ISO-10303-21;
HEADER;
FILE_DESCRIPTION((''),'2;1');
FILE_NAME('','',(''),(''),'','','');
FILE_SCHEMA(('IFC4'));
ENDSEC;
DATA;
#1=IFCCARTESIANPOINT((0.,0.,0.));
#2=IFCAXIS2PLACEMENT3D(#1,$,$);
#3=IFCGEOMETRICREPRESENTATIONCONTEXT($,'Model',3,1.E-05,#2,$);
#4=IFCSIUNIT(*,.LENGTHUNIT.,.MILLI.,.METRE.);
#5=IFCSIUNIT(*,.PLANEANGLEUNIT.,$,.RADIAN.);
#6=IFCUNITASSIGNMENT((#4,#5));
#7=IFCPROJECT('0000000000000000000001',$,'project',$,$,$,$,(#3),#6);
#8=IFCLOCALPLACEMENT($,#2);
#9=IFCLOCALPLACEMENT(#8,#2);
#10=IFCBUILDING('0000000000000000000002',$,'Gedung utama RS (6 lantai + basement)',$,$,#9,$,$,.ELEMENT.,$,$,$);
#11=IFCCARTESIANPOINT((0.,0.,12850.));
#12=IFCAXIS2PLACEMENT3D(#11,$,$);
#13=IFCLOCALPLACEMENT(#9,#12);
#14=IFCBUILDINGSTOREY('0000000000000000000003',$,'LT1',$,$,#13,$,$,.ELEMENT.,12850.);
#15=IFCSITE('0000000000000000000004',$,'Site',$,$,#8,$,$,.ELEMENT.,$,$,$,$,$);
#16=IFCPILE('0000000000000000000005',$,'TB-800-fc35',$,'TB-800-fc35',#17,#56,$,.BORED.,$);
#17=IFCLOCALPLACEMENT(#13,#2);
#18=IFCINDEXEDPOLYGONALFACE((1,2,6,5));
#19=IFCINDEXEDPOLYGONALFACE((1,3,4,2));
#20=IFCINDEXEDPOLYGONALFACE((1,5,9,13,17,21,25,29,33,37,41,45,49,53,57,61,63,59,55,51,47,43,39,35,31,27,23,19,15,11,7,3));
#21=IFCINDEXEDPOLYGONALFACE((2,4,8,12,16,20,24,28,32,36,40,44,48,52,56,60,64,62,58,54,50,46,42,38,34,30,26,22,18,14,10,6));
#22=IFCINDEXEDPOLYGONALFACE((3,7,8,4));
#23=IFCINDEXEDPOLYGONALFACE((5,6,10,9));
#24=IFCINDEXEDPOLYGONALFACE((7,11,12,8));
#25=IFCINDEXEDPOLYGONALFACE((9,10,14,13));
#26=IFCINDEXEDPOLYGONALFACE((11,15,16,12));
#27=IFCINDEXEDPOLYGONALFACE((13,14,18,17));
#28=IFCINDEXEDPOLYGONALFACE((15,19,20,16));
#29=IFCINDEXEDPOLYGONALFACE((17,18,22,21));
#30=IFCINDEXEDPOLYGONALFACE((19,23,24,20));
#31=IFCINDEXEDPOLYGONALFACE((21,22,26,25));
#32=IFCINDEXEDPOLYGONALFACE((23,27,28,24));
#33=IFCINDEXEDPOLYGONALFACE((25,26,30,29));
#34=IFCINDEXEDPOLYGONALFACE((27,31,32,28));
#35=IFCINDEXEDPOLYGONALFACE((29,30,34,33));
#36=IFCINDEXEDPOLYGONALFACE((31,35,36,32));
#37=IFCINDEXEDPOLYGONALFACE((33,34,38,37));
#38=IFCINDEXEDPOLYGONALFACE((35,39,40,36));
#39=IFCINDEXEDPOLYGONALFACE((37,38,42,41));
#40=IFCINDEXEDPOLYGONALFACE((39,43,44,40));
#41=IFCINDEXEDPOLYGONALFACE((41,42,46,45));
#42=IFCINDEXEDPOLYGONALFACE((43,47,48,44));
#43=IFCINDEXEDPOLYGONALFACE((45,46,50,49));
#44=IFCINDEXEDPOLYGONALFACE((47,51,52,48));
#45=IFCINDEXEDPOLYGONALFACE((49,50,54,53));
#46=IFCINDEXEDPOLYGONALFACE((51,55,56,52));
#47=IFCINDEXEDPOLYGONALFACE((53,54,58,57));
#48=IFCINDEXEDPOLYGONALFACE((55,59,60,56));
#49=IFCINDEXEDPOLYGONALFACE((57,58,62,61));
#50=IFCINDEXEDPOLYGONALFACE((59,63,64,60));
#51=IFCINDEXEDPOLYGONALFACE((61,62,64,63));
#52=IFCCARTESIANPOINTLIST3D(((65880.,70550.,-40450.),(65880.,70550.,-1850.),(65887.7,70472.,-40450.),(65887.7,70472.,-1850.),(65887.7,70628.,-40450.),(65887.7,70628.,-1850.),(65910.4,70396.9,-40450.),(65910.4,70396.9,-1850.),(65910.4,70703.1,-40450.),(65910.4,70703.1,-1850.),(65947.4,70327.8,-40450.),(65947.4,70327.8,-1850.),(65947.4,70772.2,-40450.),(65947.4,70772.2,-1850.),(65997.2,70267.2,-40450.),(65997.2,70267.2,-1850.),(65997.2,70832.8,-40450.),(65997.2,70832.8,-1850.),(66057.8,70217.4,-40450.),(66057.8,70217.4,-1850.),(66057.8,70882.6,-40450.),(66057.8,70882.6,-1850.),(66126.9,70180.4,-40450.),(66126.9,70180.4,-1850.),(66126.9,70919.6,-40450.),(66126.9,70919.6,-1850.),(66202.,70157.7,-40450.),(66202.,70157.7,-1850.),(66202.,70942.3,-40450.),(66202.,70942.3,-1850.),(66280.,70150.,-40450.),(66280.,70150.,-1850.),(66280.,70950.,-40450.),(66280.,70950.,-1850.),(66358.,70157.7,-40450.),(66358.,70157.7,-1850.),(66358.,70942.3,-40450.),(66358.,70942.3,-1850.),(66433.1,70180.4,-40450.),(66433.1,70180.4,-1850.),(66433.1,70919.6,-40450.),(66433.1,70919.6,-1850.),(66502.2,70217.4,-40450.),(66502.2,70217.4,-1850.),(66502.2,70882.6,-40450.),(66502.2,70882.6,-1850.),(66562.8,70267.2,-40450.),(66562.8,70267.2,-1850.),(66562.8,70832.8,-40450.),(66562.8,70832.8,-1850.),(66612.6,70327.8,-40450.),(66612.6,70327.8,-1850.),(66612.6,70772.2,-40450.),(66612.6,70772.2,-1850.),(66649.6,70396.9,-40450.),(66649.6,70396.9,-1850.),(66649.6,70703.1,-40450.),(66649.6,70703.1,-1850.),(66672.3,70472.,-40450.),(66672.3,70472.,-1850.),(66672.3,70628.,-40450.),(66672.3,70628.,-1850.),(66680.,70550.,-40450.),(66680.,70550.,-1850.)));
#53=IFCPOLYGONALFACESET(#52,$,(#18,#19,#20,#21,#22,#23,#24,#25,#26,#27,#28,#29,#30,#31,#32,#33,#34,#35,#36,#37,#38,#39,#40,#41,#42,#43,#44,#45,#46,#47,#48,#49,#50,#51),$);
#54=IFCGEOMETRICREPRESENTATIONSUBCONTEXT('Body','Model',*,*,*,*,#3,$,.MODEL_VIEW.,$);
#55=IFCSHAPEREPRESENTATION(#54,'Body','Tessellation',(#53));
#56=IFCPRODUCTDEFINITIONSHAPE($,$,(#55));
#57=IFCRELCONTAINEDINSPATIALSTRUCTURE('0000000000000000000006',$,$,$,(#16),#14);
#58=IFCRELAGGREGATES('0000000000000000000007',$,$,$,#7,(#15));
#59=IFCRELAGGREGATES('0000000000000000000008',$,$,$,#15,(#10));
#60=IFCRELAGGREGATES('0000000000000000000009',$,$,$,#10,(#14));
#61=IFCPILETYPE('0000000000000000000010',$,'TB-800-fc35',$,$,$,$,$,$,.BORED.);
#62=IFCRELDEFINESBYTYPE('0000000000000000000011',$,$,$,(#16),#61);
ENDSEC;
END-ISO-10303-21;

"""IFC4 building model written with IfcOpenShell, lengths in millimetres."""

from ifc_helpers import new_model, si_unit, frame, origin, origin_2d, place, context, subcontext, project, spatial, circle, extrude, material_profile, profile_set, profile_usage, type_object, element, save


model = new_model("IFC4")

# Units and contexts
model_context = context("Model", 3, precision=1e-05, world=origin())
body_context = subcontext(model_context, "Body", "Model", "MODEL_VIEW")
ifc_project = project(units=[si_unit("LENGTHUNIT", "METRE", prefix="MILLI"), si_unit("PLANEANGLEUNIT", "RADIAN")], contexts=[model_context])

# Site, building, storey
site_placement = place(None, origin())
site = spatial("IfcSite", under=ifc_project, at=site_placement, Name="Site", CompositionType="ELEMENT")
building_placement = place(site_placement, origin())
building = spatial("IfcBuilding", under=site, at=building_placement, Name="Gedung utama RS (6 lantai + basement)", CompositionType="ELEMENT")
storey_placement = place(building_placement, frame((0.0, 0.0, 12850.0)))
storey = spatial("IfcBuildingStorey", under=building, at=storey_placement, Name="LT1", CompositionType="ELEMENT", Elevation=12850.0)

# Pile
ifc_material_profile = material_profile(None, circle(Radius=400.0, at=origin_2d()), Name="TB-800-fc35")
ifc_profile_set = profile_set([ifc_material_profile], Name="TB-800-fc35")
ifc_profile_usage = profile_usage(ifc_profile_set, cardinal=5)
pile_type = type_object("IfcPileType", Name="TB-800-fc35", PredefinedType="BORED")
for number, where, z_axis, x_axis, name in (
    (1, (66280.0, 70550.0, -40450.0), (0.0, 0.0, 1.0), (1.0, 0.0, 0.0), "TB-800-fc35"),
):
    element("IfcPile", number, at=place(storey_placement, frame(where, z_axis=z_axis, x_axis=x_axis)), inside=storey, type_object=pile_type, material=ifc_profile_usage, Name=name, ObjectType="TB-800-fc35", PredefinedType="BORED", context=body_context, shape_type="SweptSolid", body=[
        extrude(circle(Radius=400.0, at=origin_2d()), origin(), (0.0, 0.0, 1.0), 38600.0),
    ])

save(model, "model.ifc")
